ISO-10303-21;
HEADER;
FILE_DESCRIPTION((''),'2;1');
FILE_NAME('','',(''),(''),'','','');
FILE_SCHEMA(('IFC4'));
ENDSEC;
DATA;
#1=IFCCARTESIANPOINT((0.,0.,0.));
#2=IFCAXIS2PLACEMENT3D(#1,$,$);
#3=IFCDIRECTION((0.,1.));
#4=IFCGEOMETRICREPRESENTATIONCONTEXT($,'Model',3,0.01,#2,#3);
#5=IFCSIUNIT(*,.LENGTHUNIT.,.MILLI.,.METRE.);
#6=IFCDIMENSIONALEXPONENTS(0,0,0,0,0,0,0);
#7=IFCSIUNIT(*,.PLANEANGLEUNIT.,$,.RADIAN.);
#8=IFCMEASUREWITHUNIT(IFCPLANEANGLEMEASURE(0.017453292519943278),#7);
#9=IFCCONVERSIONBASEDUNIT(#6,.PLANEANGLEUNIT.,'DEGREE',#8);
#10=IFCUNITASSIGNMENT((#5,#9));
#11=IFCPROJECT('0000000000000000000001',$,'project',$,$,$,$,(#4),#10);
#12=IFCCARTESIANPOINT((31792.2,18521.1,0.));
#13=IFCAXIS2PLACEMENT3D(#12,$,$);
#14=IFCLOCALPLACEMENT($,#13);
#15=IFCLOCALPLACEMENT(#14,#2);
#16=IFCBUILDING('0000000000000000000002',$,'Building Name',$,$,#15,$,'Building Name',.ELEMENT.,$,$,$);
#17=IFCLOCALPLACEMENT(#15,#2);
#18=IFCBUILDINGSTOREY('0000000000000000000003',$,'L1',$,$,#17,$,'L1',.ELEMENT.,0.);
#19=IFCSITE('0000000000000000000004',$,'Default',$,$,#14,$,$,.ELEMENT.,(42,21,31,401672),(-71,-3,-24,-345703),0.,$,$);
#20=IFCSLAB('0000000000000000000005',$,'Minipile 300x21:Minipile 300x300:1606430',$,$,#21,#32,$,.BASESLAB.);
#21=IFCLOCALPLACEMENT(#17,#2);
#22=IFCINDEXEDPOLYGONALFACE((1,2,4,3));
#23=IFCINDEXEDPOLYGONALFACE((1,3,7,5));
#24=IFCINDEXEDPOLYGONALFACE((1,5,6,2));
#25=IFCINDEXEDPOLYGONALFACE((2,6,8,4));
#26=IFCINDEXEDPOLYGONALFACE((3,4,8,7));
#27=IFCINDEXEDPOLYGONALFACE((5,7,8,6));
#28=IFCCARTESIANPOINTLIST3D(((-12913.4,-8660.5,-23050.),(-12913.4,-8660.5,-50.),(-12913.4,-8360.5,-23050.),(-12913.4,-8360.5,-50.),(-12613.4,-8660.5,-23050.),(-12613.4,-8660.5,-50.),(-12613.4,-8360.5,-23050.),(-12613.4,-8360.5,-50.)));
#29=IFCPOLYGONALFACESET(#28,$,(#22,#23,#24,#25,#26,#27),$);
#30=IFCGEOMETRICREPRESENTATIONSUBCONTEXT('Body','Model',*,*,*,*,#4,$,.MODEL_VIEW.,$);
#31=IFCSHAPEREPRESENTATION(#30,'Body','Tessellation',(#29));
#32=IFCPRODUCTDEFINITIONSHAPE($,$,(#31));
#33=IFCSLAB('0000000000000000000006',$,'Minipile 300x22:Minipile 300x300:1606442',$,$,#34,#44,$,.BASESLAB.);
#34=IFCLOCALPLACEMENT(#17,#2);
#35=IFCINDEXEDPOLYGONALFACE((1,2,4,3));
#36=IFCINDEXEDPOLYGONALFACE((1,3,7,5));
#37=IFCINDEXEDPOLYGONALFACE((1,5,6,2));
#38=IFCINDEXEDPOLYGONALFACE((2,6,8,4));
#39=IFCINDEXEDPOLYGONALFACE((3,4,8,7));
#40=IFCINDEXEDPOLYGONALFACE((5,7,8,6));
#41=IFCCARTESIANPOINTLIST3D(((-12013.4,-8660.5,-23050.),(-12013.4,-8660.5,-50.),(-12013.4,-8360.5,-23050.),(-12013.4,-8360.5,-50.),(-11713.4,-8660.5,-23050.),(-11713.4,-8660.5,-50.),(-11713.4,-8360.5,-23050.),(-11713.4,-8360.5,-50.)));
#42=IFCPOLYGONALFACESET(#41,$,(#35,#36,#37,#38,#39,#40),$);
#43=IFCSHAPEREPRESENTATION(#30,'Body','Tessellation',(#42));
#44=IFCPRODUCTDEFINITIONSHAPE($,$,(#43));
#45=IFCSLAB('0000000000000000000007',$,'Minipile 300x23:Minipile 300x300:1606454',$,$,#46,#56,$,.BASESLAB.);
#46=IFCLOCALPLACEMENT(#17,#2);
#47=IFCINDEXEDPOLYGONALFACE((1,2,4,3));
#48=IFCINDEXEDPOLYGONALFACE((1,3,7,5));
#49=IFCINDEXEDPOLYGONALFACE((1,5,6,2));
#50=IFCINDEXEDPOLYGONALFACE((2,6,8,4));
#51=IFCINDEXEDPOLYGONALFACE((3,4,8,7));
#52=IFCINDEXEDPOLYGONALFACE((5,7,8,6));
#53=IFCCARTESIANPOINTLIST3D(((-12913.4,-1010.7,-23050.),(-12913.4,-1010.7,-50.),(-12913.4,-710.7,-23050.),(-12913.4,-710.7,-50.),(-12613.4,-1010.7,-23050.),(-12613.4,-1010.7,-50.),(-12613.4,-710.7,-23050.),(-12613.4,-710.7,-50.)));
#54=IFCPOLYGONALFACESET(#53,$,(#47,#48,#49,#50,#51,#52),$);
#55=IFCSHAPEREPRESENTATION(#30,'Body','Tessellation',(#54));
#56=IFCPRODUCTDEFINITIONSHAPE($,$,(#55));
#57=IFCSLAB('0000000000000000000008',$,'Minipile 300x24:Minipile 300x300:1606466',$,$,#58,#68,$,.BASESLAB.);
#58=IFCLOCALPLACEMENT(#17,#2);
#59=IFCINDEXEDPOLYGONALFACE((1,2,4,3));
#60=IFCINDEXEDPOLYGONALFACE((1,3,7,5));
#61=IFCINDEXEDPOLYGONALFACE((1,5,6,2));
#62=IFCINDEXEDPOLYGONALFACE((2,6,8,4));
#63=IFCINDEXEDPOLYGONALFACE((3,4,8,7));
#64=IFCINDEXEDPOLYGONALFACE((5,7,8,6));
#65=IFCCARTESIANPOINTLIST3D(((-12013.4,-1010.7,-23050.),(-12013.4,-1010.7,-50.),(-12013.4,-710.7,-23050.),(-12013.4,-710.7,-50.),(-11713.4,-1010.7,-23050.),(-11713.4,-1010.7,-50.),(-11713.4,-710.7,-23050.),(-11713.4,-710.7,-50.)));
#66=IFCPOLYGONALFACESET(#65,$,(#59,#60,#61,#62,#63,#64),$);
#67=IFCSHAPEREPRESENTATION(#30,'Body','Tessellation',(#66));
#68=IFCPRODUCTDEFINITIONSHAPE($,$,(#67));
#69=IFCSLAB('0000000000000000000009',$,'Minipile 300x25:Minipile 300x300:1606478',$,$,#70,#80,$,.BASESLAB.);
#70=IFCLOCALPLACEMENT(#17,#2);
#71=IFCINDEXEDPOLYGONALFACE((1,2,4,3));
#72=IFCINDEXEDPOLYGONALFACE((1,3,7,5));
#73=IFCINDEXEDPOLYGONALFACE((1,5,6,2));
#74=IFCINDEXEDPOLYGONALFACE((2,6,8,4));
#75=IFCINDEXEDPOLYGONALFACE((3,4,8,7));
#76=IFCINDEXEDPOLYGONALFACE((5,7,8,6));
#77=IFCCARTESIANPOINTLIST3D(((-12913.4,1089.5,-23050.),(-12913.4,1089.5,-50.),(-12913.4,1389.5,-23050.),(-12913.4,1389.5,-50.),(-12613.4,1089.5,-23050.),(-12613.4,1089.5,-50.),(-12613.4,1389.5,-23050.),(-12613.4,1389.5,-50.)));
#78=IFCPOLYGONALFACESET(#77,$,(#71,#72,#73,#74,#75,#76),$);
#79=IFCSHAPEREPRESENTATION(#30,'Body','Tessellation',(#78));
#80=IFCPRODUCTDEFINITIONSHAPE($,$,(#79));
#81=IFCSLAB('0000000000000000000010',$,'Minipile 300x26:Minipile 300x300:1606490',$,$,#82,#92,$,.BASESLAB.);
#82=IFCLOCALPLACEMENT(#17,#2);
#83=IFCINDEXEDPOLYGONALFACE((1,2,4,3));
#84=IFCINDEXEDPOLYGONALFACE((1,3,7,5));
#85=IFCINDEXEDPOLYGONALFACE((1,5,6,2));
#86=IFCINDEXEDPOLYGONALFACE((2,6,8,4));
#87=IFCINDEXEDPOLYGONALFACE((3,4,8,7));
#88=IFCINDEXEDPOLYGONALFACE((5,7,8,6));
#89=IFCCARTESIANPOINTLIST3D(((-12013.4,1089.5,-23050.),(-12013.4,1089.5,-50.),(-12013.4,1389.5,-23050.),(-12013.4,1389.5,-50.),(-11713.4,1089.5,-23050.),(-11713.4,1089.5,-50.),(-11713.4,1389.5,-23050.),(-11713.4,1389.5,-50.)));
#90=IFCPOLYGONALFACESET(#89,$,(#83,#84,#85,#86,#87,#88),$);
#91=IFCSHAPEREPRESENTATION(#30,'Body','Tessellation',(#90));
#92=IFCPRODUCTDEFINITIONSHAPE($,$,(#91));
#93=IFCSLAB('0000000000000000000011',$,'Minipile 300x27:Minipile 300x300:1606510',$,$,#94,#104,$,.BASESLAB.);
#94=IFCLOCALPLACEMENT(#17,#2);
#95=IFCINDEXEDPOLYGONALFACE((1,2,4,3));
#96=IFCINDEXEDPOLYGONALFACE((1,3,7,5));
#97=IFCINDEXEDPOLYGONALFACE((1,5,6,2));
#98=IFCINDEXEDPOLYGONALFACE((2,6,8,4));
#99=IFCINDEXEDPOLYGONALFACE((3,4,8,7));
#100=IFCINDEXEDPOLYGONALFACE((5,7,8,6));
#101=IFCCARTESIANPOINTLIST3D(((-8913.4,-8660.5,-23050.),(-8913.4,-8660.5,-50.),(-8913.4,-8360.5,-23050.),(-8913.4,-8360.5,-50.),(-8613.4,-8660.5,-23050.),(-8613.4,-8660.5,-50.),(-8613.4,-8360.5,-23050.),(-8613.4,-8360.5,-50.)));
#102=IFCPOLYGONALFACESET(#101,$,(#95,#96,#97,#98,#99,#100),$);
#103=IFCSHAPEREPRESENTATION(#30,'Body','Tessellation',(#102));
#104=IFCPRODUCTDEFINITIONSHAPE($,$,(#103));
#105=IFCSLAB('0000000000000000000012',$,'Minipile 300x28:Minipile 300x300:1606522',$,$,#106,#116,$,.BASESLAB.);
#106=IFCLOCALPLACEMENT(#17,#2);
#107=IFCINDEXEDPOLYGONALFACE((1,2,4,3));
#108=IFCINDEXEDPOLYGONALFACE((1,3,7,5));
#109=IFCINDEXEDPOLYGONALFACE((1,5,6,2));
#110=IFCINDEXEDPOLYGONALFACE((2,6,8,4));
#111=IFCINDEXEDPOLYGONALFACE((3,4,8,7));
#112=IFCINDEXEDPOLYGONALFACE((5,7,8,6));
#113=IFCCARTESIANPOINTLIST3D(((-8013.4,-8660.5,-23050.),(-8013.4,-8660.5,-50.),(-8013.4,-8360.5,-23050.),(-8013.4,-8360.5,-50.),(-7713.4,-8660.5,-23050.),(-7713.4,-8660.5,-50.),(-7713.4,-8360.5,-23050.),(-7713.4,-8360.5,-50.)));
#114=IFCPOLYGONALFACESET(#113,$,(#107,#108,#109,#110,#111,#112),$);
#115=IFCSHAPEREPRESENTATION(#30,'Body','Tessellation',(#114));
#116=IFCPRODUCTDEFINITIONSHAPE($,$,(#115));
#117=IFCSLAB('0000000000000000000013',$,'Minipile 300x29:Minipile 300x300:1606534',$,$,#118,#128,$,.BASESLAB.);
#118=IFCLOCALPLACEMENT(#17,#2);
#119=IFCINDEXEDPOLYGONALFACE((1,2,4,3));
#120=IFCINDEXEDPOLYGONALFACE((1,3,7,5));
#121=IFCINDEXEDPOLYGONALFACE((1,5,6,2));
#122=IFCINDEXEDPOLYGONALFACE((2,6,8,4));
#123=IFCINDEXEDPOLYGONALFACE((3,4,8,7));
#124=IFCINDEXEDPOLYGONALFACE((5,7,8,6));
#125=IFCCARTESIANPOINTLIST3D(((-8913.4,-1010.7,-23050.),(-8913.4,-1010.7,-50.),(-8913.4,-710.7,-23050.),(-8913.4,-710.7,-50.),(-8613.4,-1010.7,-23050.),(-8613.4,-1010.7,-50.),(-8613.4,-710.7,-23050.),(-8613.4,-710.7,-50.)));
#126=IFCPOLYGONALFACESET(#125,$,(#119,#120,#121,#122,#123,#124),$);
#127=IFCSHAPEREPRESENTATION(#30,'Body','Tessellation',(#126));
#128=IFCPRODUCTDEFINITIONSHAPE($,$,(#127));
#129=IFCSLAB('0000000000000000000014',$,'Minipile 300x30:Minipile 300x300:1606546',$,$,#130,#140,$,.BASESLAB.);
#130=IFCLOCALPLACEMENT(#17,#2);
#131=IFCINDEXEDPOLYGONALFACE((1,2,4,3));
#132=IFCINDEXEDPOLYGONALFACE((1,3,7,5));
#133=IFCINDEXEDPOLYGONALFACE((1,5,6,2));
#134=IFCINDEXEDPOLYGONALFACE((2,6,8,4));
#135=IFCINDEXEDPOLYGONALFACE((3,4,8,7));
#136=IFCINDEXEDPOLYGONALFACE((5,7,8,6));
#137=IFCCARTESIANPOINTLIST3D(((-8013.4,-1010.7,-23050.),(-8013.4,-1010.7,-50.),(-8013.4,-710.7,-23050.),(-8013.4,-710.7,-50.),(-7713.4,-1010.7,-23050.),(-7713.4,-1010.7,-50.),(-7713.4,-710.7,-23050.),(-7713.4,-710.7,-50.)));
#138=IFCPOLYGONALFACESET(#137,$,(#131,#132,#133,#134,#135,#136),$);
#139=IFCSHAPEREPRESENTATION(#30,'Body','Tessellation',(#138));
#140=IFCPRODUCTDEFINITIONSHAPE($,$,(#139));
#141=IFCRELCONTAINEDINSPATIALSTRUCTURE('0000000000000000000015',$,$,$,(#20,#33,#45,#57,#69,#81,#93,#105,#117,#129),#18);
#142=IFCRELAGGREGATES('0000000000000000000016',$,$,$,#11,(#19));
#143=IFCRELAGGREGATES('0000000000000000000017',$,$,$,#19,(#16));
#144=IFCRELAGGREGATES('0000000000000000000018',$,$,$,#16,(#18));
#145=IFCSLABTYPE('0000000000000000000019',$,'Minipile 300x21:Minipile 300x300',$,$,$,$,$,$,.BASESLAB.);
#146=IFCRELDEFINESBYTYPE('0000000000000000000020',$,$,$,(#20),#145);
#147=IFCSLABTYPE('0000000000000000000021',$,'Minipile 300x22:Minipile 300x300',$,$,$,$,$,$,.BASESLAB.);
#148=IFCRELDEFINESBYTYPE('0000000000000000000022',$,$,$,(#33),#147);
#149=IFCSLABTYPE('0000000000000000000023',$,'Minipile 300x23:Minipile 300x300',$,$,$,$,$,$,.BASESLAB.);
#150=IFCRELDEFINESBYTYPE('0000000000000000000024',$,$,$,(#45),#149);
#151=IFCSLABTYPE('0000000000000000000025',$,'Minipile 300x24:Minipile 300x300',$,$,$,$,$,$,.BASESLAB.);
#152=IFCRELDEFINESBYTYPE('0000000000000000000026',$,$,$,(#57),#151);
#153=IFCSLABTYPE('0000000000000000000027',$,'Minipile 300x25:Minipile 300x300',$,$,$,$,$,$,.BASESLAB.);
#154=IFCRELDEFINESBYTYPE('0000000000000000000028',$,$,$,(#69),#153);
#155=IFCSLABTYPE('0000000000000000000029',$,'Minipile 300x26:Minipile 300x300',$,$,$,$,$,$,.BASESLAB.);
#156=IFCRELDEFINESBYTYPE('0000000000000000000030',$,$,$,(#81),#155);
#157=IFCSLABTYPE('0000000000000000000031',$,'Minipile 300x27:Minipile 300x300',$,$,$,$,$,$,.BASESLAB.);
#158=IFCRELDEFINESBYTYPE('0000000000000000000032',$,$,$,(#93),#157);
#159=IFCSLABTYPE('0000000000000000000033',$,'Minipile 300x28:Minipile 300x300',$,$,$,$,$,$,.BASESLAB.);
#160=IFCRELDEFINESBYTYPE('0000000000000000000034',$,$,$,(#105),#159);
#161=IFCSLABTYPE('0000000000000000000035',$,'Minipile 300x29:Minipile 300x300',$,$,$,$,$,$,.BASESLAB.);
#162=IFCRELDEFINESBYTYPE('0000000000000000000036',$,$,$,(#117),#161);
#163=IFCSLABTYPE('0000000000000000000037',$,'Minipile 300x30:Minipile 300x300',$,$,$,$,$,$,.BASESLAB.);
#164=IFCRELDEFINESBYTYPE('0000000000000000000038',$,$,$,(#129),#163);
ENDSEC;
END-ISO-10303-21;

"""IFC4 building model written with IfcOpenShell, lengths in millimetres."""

from ifc_helpers import new_model, entity, si_unit, converted_unit, direction, frame, origin, place, context, subcontext, project, spatial, indexed_curve, outline, extrude, type_object, element, save


model = new_model("IFC4")

# Units and contexts
model_context = context("Model", 3, precision=0.01, world=origin(), true_north=direction((0.0, 1.0)))
body_context = subcontext(model_context, "Body", "Model", "MODEL_VIEW")
ifc_project = project(units=[si_unit("LENGTHUNIT", "METRE", prefix="MILLI"), converted_unit("PLANEANGLEUNIT", "DEGREE", entity("IfcPlaneAngleMeasure", 0.017453292519943278), si_unit("PLANEANGLEUNIT", "RADIAN"), dimensions=[0, 0, 0, 0, 0, 0, 0])], contexts=[model_context])

# Site, building, storey
site_placement = place(None, frame((31792.2, 18521.1, 0.0)))
site = spatial("IfcSite", under=ifc_project, at=site_placement, Name="Default", CompositionType="ELEMENT", RefLatitude=(42, 21, 31, 401672), RefLongitude=(-71, -3, -24, -345703), RefElevation=0.0)
building_placement = place(site_placement, origin())
building = spatial("IfcBuilding", under=site, at=building_placement, Name="Building Name", LongName="Building Name", CompositionType="ELEMENT")
storey_placement = place(building_placement, origin())
storey = spatial("IfcBuildingStorey", under=building, at=storey_placement, Name="L1", LongName="L1", CompositionType="ELEMENT", Elevation=0.0)

# Slabs
slab_type_1 = type_object("IfcSlabType", Name="Minipile 300x21:Minipile 300x300", PredefinedType="BASESLAB")
slab_1_placement = place(storey_placement, origin())
element("IfcSlab", 1, at=slab_1_placement, inside=storey, type_object=slab_type_1, Name="Minipile 300x21:Minipile 300x300:1606430", PredefinedType="BASESLAB", context=body_context, shape_type="SweptSolid", body=[
    extrude(outline(indexed_curve([(-150.0, -150.0), (150.0, -150.0), (150.0, 150.0), (-150.0, 150.0), (-150.0, -150.0)], self_intersect=False)), frame((-12763.4, -8510.5, -23050.0), z_axis=(0.0, 0.0, 1.0), x_axis=(-1.0, 0.0, 0.0)), (0.0, 0.0, 1.0), 23000.0),
])
slab_type_2 = type_object("IfcSlabType", Name="Minipile 300x22:Minipile 300x300", PredefinedType="BASESLAB")
slab_2_placement = place(storey_placement, origin())
element("IfcSlab", 2, at=slab_2_placement, inside=storey, type_object=slab_type_2, Name="Minipile 300x22:Minipile 300x300:1606442", PredefinedType="BASESLAB", context=body_context, shape_type="SweptSolid", body=[
    extrude(outline(indexed_curve([(-150.0, -150.0), (150.0, -150.0), (150.0, 150.0), (-150.0, 150.0), (-150.0, -150.0)], self_intersect=False)), frame((-11863.4, -8510.5, -23050.0), z_axis=(0.0, 0.0, 1.0), x_axis=(0.0, -1.0, 0.0)), (0.0, 0.0, 1.0), 23000.0),
])
slab_type_3 = type_object("IfcSlabType", Name="Minipile 300x23:Minipile 300x300", PredefinedType="BASESLAB")
slab_3_placement = place(storey_placement, origin())
element("IfcSlab", 3, at=slab_3_placement, inside=storey, type_object=slab_type_3, Name="Minipile 300x23:Minipile 300x300:1606454", PredefinedType="BASESLAB", context=body_context, shape_type="SweptSolid", body=[
    extrude(outline(indexed_curve([(-150.0, -150.0), (150.0, -150.0), (150.0, 150.0), (-150.0, 150.0), (-150.0, -150.0)], self_intersect=False)), frame((-12763.4, -860.7, -23050.0), z_axis=(0.0, 0.0, 1.0), x_axis=(-1.0, 0.0, 0.0)), (0.0, 0.0, 1.0), 23000.0),
])
slab_type_4 = type_object("IfcSlabType", Name="Minipile 300x24:Minipile 300x300", PredefinedType="BASESLAB")
slab_4_placement = place(storey_placement, origin())
element("IfcSlab", 4, at=slab_4_placement, inside=storey, type_object=slab_type_4, Name="Minipile 300x24:Minipile 300x300:1606466", PredefinedType="BASESLAB", context=body_context, shape_type="SweptSolid", body=[
    extrude(outline(indexed_curve([(-150.0, -150.0), (150.0, -150.0), (150.0, 150.0), (-150.0, 150.0), (-150.0, -150.0)], self_intersect=False)), frame((-11863.4, -860.7, -23050.0), z_axis=(0.0, 0.0, 1.0), x_axis=(0.0, -1.0, 0.0)), (0.0, 0.0, 1.0), 23000.0),
])
slab_type_5 = type_object("IfcSlabType", Name="Minipile 300x25:Minipile 300x300", PredefinedType="BASESLAB")
slab_5_placement = place(storey_placement, origin())
element("IfcSlab", 5, at=slab_5_placement, inside=storey, type_object=slab_type_5, Name="Minipile 300x25:Minipile 300x300:1606478", PredefinedType="BASESLAB", context=body_context, shape_type="SweptSolid", body=[
    extrude(outline(indexed_curve([(-150.0, -150.0), (150.0, -150.0), (150.0, 150.0), (-150.0, 150.0), (-150.0, -150.0)], self_intersect=False)), frame((-12763.4, 1239.5, -23050.0), z_axis=(0.0, 0.0, 1.0), x_axis=(-1.0, 0.0, 0.0)), (0.0, 0.0, 1.0), 23000.0),
])
slab_type_6 = type_object("IfcSlabType", Name="Minipile 300x26:Minipile 300x300", PredefinedType="BASESLAB")
slab_6_placement = place(storey_placement, origin())
element("IfcSlab", 6, at=slab_6_placement, inside=storey, type_object=slab_type_6, Name="Minipile 300x26:Minipile 300x300:1606490", PredefinedType="BASESLAB", context=body_context, shape_type="SweptSolid", body=[
    extrude(outline(indexed_curve([(-150.0, -150.0), (150.0, -150.0), (150.0, 150.0), (-150.0, 150.0), (-150.0, -150.0)], self_intersect=False)), frame((-11863.4, 1239.5, -23050.0), z_axis=(0.0, 0.0, 1.0), x_axis=(0.0, -1.0, 0.0)), (0.0, 0.0, 1.0), 23000.0),
])
slab_type_7 = type_object("IfcSlabType", Name="Minipile 300x27:Minipile 300x300", PredefinedType="BASESLAB")
slab_7_placement = place(storey_placement, origin())
element("IfcSlab", 7, at=slab_7_placement, inside=storey, type_object=slab_type_7, Name="Minipile 300x27:Minipile 300x300:1606510", PredefinedType="BASESLAB", context=body_context, shape_type="SweptSolid", body=[
    extrude(outline(indexed_curve([(-150.0, -150.0), (150.0, -150.0), (150.0, 150.0), (-150.0, 150.0), (-150.0, -150.0)], self_intersect=False)), frame((-8763.4, -8510.5, -23050.0), z_axis=(0.0, 0.0, 1.0), x_axis=(-1.0, 0.0, 0.0)), (0.0, 0.0, 1.0), 23000.0),
])
slab_type_8 = type_object("IfcSlabType", Name="Minipile 300x28:Minipile 300x300", PredefinedType="BASESLAB")
slab_8_placement = place(storey_placement, origin())
element("IfcSlab", 8, at=slab_8_placement, inside=storey, type_object=slab_type_8, Name="Minipile 300x28:Minipile 300x300:1606522", PredefinedType="BASESLAB", context=body_context, shape_type="SweptSolid", body=[
    extrude(outline(indexed_curve([(-150.0, -150.0), (150.0, -150.0), (150.0, 150.0), (-150.0, 150.0), (-150.0, -150.0)], self_intersect=False)), frame((-7863.4, -8510.5, -23050.0), z_axis=(0.0, 0.0, 1.0), x_axis=(0.0, -1.0, 0.0)), (0.0, 0.0, 1.0), 23000.0),
])
slab_type_9 = type_object("IfcSlabType", Name="Minipile 300x29:Minipile 300x300", PredefinedType="BASESLAB")
slab_9_placement = place(storey_placement, origin())
element("IfcSlab", 9, at=slab_9_placement, inside=storey, type_object=slab_type_9, Name="Minipile 300x29:Minipile 300x300:1606534", PredefinedType="BASESLAB", context=body_context, shape_type="SweptSolid", body=[
    extrude(outline(indexed_curve([(-150.0, -150.0), (150.0, -150.0), (150.0, 150.0), (-150.0, 150.0), (-150.0, -150.0)], self_intersect=False)), frame((-8763.4, -860.7, -23050.0), z_axis=(0.0, 0.0, 1.0), x_axis=(-1.0, 0.0, 0.0)), (0.0, 0.0, 1.0), 23000.0),
])
slab_type_10 = type_object("IfcSlabType", Name="Minipile 300x30:Minipile 300x300", PredefinedType="BASESLAB")
slab_10_placement = place(storey_placement, origin())
element("IfcSlab", 10, at=slab_10_placement, inside=storey, type_object=slab_type_10, Name="Minipile 300x30:Minipile 300x300:1606546", PredefinedType="BASESLAB", context=body_context, shape_type="SweptSolid", body=[
    extrude(outline(indexed_curve([(-150.0, -150.0), (150.0, -150.0), (150.0, 150.0), (-150.0, 150.0), (-150.0, -150.0)], self_intersect=False)), frame((-7863.4, -860.7, -23050.0), z_axis=(0.0, 0.0, 1.0), x_axis=(0.0, -1.0, 0.0)), (0.0, 0.0, 1.0), 23000.0),
])

save(model, "model.ifc")
